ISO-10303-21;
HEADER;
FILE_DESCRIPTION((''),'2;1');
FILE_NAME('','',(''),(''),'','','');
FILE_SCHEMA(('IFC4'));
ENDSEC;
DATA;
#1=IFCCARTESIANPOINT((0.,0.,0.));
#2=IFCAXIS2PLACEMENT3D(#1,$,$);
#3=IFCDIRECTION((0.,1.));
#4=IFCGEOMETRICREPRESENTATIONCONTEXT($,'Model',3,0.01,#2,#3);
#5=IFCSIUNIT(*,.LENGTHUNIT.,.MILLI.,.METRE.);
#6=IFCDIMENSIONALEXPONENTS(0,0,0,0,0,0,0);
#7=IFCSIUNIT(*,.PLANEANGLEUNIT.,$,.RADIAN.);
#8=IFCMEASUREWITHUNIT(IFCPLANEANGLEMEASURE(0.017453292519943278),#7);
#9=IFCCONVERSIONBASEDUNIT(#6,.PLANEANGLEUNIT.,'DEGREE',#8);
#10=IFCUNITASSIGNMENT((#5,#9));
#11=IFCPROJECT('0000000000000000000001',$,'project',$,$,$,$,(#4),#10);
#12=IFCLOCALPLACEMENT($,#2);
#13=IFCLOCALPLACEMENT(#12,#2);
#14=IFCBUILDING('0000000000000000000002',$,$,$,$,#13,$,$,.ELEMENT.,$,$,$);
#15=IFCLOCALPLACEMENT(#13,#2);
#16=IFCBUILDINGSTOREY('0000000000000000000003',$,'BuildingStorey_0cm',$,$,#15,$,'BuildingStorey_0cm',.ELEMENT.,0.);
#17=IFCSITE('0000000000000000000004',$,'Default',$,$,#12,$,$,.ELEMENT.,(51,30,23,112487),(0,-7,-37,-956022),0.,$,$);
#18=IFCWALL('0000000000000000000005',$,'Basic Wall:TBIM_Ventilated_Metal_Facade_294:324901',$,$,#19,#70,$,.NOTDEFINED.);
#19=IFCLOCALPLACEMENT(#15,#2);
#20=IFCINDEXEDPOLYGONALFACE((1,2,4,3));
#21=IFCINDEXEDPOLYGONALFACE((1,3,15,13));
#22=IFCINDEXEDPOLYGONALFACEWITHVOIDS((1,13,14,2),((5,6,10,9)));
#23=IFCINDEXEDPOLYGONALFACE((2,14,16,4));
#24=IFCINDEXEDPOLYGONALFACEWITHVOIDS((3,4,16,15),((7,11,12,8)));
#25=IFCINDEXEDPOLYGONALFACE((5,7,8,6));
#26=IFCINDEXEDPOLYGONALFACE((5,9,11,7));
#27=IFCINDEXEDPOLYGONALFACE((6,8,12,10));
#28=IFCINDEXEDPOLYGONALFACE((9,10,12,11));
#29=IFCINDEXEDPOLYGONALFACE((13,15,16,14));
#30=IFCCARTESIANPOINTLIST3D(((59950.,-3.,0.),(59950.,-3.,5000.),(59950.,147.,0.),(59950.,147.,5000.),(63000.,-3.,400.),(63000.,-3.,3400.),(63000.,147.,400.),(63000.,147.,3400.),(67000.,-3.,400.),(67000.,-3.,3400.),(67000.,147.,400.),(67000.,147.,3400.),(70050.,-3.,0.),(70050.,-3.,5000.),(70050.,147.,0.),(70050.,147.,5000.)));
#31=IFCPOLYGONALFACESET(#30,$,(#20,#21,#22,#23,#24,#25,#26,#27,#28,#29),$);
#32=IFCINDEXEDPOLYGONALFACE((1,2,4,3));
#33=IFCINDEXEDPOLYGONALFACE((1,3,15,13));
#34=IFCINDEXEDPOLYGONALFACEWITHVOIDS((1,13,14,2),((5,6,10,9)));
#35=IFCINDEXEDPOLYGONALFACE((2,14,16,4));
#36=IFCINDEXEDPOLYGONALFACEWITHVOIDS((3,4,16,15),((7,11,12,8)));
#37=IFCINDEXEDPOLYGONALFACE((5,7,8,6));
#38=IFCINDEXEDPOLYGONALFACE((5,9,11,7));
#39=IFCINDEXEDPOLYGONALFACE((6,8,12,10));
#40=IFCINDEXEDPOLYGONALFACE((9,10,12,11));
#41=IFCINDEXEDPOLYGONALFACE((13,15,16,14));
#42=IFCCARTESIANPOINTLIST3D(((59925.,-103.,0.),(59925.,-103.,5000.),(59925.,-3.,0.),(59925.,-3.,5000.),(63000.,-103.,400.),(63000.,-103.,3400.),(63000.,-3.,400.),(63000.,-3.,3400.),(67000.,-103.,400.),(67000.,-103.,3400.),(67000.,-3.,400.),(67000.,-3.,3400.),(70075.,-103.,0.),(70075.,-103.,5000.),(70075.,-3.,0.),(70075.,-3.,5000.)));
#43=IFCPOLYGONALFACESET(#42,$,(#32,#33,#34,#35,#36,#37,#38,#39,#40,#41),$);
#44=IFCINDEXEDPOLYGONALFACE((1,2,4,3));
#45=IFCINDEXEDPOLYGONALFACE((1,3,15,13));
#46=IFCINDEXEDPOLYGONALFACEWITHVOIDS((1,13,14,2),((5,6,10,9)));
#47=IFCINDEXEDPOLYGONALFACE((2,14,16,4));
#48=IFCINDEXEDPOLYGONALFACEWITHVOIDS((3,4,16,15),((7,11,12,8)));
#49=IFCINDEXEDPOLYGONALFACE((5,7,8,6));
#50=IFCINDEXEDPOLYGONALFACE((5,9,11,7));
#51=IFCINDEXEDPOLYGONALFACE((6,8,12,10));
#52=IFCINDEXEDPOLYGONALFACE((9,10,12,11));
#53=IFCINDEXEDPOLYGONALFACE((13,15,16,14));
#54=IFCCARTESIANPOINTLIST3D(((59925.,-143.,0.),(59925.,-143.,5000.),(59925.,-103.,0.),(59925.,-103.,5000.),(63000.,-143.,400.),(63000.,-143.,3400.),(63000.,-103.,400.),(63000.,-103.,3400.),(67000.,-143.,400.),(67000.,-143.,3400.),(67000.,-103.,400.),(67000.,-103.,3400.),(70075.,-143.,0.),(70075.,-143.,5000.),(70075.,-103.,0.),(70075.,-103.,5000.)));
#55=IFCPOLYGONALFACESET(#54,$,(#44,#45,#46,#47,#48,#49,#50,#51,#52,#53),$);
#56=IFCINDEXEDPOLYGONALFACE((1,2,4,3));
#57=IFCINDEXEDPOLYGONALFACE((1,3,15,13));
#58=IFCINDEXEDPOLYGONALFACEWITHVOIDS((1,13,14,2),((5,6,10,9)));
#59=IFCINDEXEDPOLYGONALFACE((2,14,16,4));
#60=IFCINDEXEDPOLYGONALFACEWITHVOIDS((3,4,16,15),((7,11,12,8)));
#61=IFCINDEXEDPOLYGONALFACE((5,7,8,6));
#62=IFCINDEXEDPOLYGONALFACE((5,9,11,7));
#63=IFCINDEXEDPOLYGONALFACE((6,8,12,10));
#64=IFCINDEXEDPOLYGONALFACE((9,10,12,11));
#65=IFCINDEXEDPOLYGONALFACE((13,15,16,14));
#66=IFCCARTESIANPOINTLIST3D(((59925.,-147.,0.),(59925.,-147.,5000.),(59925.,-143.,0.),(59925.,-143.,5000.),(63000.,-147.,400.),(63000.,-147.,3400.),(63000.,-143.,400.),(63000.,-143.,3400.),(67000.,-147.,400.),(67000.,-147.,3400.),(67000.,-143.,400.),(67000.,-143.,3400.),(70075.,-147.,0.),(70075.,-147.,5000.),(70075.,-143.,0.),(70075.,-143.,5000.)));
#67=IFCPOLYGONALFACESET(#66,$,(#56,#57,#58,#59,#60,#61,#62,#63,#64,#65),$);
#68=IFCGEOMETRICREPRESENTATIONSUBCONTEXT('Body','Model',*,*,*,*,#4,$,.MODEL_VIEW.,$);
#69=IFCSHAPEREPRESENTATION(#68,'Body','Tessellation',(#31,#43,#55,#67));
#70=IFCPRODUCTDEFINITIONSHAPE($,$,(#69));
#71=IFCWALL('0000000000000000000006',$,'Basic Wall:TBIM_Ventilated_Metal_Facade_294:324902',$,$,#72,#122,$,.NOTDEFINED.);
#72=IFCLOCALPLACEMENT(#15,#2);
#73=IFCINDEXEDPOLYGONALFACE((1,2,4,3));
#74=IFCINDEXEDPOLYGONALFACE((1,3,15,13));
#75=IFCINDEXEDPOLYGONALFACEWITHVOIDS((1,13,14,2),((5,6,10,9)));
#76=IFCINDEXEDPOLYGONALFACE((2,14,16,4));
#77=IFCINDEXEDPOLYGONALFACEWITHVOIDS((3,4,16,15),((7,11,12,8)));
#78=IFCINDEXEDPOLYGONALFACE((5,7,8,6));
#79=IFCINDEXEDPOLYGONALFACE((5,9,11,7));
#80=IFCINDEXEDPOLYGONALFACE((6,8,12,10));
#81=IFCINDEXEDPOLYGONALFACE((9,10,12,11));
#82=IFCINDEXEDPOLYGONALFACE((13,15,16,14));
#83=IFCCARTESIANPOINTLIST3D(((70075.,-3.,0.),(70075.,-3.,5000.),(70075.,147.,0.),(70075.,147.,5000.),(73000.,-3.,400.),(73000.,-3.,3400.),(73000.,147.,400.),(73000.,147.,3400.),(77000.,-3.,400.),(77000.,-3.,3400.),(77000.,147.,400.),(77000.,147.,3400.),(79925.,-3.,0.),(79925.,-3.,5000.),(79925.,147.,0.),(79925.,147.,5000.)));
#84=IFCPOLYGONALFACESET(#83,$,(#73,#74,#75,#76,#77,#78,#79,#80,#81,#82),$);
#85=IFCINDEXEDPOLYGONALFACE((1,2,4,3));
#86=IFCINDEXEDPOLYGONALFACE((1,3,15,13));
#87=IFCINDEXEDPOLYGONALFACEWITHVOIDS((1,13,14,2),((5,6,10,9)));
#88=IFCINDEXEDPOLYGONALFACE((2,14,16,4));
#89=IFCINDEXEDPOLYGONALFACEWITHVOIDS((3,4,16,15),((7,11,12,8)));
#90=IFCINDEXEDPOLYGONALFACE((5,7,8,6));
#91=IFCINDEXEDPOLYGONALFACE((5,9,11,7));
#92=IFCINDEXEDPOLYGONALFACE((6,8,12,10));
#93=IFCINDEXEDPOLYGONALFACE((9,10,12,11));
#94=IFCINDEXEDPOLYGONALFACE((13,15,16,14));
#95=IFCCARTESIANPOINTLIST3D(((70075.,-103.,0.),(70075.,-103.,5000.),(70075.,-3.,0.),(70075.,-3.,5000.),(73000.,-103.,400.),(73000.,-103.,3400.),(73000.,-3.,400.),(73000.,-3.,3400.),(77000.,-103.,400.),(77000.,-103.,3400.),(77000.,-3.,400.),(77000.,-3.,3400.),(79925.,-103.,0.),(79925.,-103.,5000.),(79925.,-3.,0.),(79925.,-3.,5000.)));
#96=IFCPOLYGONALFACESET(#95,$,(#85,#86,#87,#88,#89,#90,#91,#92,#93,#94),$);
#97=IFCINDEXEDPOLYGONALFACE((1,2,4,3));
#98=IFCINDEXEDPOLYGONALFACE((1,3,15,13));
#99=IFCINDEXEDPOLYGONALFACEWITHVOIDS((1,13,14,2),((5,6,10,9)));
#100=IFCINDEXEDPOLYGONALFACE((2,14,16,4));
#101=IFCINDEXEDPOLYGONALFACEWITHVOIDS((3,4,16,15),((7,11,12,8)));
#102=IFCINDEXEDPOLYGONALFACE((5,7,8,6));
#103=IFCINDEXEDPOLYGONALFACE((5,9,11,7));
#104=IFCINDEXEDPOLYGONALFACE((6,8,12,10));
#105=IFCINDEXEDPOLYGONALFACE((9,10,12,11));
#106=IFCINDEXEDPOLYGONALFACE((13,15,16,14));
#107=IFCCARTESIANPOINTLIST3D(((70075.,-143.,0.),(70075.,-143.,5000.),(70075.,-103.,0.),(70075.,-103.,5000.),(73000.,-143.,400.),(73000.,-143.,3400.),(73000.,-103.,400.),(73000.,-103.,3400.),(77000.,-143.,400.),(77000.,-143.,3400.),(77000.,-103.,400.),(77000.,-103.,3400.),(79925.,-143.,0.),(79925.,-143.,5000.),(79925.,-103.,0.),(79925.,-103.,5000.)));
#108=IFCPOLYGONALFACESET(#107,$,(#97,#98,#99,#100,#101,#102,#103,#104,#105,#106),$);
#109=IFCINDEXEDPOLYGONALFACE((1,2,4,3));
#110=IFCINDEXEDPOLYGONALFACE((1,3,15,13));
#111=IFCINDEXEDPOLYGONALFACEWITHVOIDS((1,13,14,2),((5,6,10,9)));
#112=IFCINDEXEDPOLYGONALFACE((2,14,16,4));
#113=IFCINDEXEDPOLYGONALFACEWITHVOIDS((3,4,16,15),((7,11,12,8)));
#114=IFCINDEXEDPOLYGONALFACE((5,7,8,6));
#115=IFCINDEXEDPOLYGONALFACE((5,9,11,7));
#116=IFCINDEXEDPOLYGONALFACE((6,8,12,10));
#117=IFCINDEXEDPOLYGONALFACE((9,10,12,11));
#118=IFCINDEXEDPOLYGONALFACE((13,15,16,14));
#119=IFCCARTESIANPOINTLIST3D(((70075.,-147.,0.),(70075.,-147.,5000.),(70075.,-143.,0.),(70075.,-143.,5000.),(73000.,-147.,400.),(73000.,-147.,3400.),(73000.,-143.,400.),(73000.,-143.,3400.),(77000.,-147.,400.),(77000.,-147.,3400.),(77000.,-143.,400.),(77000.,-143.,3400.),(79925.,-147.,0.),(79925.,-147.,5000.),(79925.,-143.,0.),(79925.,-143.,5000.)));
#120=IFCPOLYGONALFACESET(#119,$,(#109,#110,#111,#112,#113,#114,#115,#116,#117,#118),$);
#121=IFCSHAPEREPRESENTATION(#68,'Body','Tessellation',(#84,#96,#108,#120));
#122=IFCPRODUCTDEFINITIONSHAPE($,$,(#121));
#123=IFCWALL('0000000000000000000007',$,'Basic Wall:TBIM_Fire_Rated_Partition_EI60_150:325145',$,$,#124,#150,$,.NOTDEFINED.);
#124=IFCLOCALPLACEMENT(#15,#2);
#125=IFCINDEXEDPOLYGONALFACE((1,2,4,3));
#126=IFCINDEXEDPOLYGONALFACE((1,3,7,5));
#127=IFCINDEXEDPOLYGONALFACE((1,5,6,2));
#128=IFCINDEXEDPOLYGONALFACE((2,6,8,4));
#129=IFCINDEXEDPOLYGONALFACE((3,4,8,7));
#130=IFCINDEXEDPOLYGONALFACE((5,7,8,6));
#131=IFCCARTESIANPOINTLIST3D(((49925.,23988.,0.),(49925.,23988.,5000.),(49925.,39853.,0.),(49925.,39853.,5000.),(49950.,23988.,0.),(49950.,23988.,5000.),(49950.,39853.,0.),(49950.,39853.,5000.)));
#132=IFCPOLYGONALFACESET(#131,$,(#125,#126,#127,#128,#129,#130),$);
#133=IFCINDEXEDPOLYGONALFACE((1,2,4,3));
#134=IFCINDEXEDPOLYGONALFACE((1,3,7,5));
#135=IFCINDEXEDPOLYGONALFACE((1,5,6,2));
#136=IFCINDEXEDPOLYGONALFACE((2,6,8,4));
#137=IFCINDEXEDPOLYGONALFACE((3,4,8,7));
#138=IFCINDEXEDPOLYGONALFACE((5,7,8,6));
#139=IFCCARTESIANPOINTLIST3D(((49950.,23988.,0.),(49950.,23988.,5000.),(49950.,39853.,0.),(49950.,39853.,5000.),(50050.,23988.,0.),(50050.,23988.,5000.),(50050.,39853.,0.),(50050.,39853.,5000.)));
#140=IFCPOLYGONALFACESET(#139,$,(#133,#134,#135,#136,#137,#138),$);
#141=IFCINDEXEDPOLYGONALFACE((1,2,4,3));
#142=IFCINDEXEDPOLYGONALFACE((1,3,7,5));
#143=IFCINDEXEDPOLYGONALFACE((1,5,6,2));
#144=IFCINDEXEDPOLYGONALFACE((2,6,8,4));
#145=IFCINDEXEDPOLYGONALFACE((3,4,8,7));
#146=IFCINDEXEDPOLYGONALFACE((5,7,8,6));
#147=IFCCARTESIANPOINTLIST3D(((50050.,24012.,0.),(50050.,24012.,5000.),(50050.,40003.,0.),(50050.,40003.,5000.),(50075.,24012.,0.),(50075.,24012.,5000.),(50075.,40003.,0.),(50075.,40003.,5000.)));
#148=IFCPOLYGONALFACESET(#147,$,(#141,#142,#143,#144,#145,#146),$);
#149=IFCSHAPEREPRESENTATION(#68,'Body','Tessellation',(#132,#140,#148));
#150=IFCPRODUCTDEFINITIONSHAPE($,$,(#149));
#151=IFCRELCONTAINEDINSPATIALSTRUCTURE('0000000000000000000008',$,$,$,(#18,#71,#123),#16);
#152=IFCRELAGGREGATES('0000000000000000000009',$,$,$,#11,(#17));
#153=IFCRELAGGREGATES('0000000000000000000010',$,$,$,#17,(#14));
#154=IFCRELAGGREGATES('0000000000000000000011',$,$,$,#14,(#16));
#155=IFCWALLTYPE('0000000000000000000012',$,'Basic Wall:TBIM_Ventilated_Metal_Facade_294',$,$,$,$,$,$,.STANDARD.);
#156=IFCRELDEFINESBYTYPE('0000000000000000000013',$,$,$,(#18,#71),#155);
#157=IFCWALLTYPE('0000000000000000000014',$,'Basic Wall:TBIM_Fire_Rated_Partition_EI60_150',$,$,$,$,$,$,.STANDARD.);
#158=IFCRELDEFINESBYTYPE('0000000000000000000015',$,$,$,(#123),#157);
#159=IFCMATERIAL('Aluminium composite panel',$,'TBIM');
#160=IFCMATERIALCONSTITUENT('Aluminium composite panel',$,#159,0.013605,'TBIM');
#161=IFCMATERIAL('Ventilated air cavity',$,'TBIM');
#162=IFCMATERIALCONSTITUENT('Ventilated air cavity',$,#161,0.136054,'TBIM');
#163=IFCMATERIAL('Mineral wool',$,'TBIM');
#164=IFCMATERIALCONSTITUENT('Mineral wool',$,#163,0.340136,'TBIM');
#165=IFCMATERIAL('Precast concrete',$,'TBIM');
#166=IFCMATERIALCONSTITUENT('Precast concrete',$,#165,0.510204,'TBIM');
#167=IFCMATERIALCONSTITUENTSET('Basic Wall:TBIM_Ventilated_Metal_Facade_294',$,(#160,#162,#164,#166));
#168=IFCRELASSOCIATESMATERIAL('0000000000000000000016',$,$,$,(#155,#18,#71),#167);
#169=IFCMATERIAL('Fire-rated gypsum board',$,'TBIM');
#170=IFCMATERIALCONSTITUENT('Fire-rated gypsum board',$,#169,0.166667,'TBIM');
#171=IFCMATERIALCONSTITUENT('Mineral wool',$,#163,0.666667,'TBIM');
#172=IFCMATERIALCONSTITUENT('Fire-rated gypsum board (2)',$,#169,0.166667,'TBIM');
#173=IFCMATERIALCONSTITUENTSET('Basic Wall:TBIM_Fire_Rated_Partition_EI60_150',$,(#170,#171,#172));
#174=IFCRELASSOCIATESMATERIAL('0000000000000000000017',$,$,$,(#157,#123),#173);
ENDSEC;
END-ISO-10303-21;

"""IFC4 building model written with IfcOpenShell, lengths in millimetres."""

from ifc_helpers import new_model, entity, si_unit, converted_unit, direction, frame, origin, place, context, subcontext, project, spatial, indexed_curve, outline, extrude, material, constituent, constituent_set, type_object, element, save


model = new_model("IFC4")

# Units and contexts
model_context = context("Model", 3, precision=0.01, world=origin(), true_north=direction((0.0, 1.0)))
body_context = subcontext(model_context, "Body", "Model", "MODEL_VIEW")
ifc_project = project(units=[si_unit("LENGTHUNIT", "METRE", prefix="MILLI"), converted_unit("PLANEANGLEUNIT", "DEGREE", entity("IfcPlaneAngleMeasure", 0.017453292519943278), si_unit("PLANEANGLEUNIT", "RADIAN"), dimensions=[0, 0, 0, 0, 0, 0, 0])], contexts=[model_context])

# Site, building, storey
site_placement = place(None, origin())
site = spatial("IfcSite", under=ifc_project, at=site_placement, Name="Default", CompositionType="ELEMENT", RefLatitude=(51, 30, 23, 112487), RefLongitude=(0, -7, -37, -956022), RefElevation=0.0)
building_placement = place(site_placement, origin())
building = spatial("IfcBuilding", under=site, at=building_placement, CompositionType="ELEMENT")
storey_placement = place(building_placement, origin())
storey = spatial("IfcBuildingStorey", under=building, at=storey_placement, Name="BuildingStorey_0cm", LongName="BuildingStorey_0cm", CompositionType="ELEMENT", Elevation=0.0)

# Walls, openings
ifc_material_1 = material(Name="Aluminium composite panel", Category="TBIM")
ifc_constituent_1 = constituent(ifc_material_1, Name="Aluminium composite panel", Category="TBIM", fraction=0.013605)
ifc_material_2 = material(Name="Ventilated air cavity", Category="TBIM")
ifc_constituent_2 = constituent(ifc_material_2, Name="Ventilated air cavity", Category="TBIM", fraction=0.136054)
ifc_material_3 = material(Name="Mineral wool", Category="TBIM")
ifc_constituent_3 = constituent(ifc_material_3, Name="Mineral wool", Category="TBIM", fraction=0.340136)
ifc_material_4 = material(Name="Precast concrete", Category="TBIM")
ifc_constituent_4 = constituent(ifc_material_4, Name="Precast concrete", Category="TBIM", fraction=0.510204)
ifc_constituent_set_1 = constituent_set(constituents=[ifc_constituent_1, ifc_constituent_2, ifc_constituent_3, ifc_constituent_4], Name="Basic Wall:TBIM_Ventilated_Metal_Facade_294")
wall_type_1 = type_object("IfcWallType", Name="Basic Wall:TBIM_Ventilated_Metal_Facade_294", PredefinedType="STANDARD", material=ifc_constituent_set_1)
wall_1_placement = place(storey_placement, frame((59925.0, 0.0, 0.0)))
wall_1 = element("IfcWall", 1, at=wall_1_placement, inside=storey, type_object=wall_type_1, material=ifc_constituent_set_1, Name="Basic Wall:TBIM_Ventilated_Metal_Facade_294:324901", PredefinedType="NOTDEFINED", context=body_context, shape_type="SweptSolid", body=[
    extrude(outline(indexed_curve([(-2500.0, -5050.0), (2500.0, -5050.0), (2500.0, 5050.0), (-2500.0, 5050.0), (-2500.0, -5050.0)], self_intersect=False), holes=[indexed_curve([(-2100.0, -2000.0), (-2100.0, 2000.0), (900.0, 2000.0), (900.0, -2000.0), (-2100.0, -2000.0)], self_intersect=False)]), frame((5075.0, -3.0, 2500.0), z_axis=(0.0, 1.0, 0.0), x_axis=(0.0, 0.0, 1.0)), (0.0, 0.0, 1.0), 150.0),
    extrude(outline(indexed_curve([(-2500.0, -5075.0), (2500.0, -5075.0), (2500.0, 5075.0), (-2500.0, 5075.0), (-2500.0, -5075.0)], self_intersect=False), holes=[indexed_curve([(-2100.0, -2000.0), (-2100.0, 2000.0), (900.0, 2000.0), (900.0, -2000.0), (-2100.0, -2000.0)], self_intersect=False)]), frame((5075.0, -103.0, 2500.0), z_axis=(0.0, 1.0, 0.0), x_axis=(0.0, 0.0, 1.0)), (0.0, 0.0, 1.0), 100.0),
    extrude(outline(indexed_curve([(-2500.0, -5075.0), (2500.0, -5075.0), (2500.0, 5075.0), (-2500.0, 5075.0), (-2500.0, -5075.0)], self_intersect=False), holes=[indexed_curve([(-2100.0, -2000.0), (-2100.0, 2000.0), (900.0, 2000.0), (900.0, -2000.0), (-2100.0, -2000.0)], self_intersect=False)]), frame((5075.0, -143.0, 2500.0), z_axis=(0.0, 1.0, 0.0), x_axis=(0.0, 0.0, 1.0)), (0.0, 0.0, 1.0), 40.0),
    extrude(outline(indexed_curve([(-2500.0, -5075.0), (2500.0, -5075.0), (2500.0, 5075.0), (-2500.0, 5075.0), (-2500.0, -5075.0)], self_intersect=False), holes=[indexed_curve([(900.0, -2000.0), (-2100.0, -2000.0), (-2100.0, 2000.0), (900.0, 2000.0), (900.0, -2000.0)], self_intersect=False)]), frame((5075.0, -147.0, 2500.0), z_axis=(0.0, 1.0, 0.0), x_axis=(0.0, 0.0, 1.0)), (0.0, 0.0, 1.0), 4.0),
])
opening_1_placement = place(wall_1_placement, frame((3075.0, -147.0, 400.0)))
element("IfcOpeningElement", 2, at=opening_1_placement, cuts=wall_1, PredefinedType="OPENING", context=body_context, shape_type="SweptSolid", body=[
    extrude(outline(indexed_curve([(3000.0, 0.0), (3000.0, 4000.0), (0.0, 4000.0), (0.0, 0.0), (3000.0, 0.0)], self_intersect=False)), frame((0.0, 0.0, 0.0), z_axis=(0.0, 1.0, 0.0), x_axis=(0.0, 0.0, 1.0)), (0.0, 0.0, 1.0), 294.0),
])
wall_2_placement = place(storey_placement, frame((70075.0, 0.0, 0.0)))
wall_2 = element("IfcWall", 3, at=wall_2_placement, inside=storey, type_object=wall_type_1, material=ifc_constituent_set_1, Name="Basic Wall:TBIM_Ventilated_Metal_Facade_294:324902", PredefinedType="NOTDEFINED", context=body_context, shape_type="SweptSolid", body=[
    extrude(outline(indexed_curve([(-2500.0, -4925.0), (2500.0, -4925.0), (2500.0, 4925.0), (-2500.0, 4925.0), (-2500.0, -4925.0)], self_intersect=False), holes=[indexed_curve([(-2100.0, -2000.0), (-2100.0, 2000.0), (900.0, 2000.0), (900.0, -2000.0), (-2100.0, -2000.0)], self_intersect=False)]), frame((4925.0, -3.0, 2500.0), z_axis=(0.0, 1.0, 0.0), x_axis=(0.0, 0.0, 1.0)), (0.0, 0.0, 1.0), 150.0),
    extrude(outline(indexed_curve([(-2500.0, -4925.0), (2500.0, -4925.0), (2500.0, 4925.0), (-2500.0, 4925.0), (-2500.0, -4925.0)], self_intersect=False), holes=[indexed_curve([(-2100.0, -2000.0), (-2100.0, 2000.0), (900.0, 2000.0), (900.0, -2000.0), (-2100.0, -2000.0)], self_intersect=False)]), frame((4925.0, -103.0, 2500.0), z_axis=(0.0, 1.0, 0.0), x_axis=(0.0, 0.0, 1.0)), (0.0, 0.0, 1.0), 100.0),
    extrude(outline(indexed_curve([(-2500.0, -4925.0), (2500.0, -4925.0), (2500.0, 4925.0), (-2500.0, 4925.0), (-2500.0, -4925.0)], self_intersect=False), holes=[indexed_curve([(-2100.0, -2000.0), (-2100.0, 2000.0), (900.0, 2000.0), (900.0, -2000.0), (-2100.0, -2000.0)], self_intersect=False)]), frame((4925.0, -143.0, 2500.0), z_axis=(0.0, 1.0, 0.0), x_axis=(0.0, 0.0, 1.0)), (0.0, 0.0, 1.0), 40.0),
    extrude(outline(indexed_curve([(-2500.0, -4925.0), (2500.0, -4925.0), (2500.0, 4925.0), (-2500.0, 4925.0), (-2500.0, -4925.0)], self_intersect=False), holes=[indexed_curve([(900.0, -2000.0), (-2100.0, -2000.0), (-2100.0, 2000.0), (900.0, 2000.0), (900.0, -2000.0)], self_intersect=False)]), frame((4925.0, -147.0, 2500.0), z_axis=(0.0, 1.0, 0.0), x_axis=(0.0, 0.0, 1.0)), (0.0, 0.0, 1.0), 4.0),
])
opening_2_placement = place(wall_2_placement, frame((2925.0, -147.0, 400.0)))
element("IfcOpeningElement", 4, at=opening_2_placement, cuts=wall_2, PredefinedType="OPENING", context=body_context, shape_type="SweptSolid", body=[
    extrude(outline(indexed_curve([(3000.0, 0.0), (3000.0, 4000.0), (0.0, 4000.0), (0.0, 0.0), (3000.0, 0.0)], self_intersect=False)), frame((0.0, 0.0, 0.0), z_axis=(0.0, 1.0, 0.0), x_axis=(0.0, 0.0, 1.0)), (0.0, 0.0, 1.0), 294.0),
])

# Wall
ifc_material_5 = material(Name="Fire-rated gypsum board", Category="TBIM")
ifc_constituent_5 = constituent(ifc_material_5, Name="Fire-rated gypsum board", Category="TBIM", fraction=0.166667)
ifc_constituent_6 = constituent(ifc_material_3, Name="Mineral wool", Category="TBIM", fraction=0.666667)
ifc_constituent_7 = constituent(ifc_material_5, Name="Fire-rated gypsum board (2)", Category="TBIM", fraction=0.166667)
ifc_constituent_set_2 = constituent_set(constituents=[ifc_constituent_5, ifc_constituent_6, ifc_constituent_7], Name="Basic Wall:TBIM_Fire_Rated_Partition_EI60_150")
wall_type_2 = type_object("IfcWallType", Name="Basic Wall:TBIM_Fire_Rated_Partition_EI60_150", PredefinedType="STANDARD", material=ifc_constituent_set_2)
wall_3_placement = place(storey_placement, frame((50000.0, 24012.0, 0.0), z_axis=(0.0, 0.0, 1.0), x_axis=(0.0, 1.0, 0.0)))
element("IfcWall", 5, at=wall_3_placement, inside=storey, type_object=wall_type_2, material=ifc_constituent_set_2, Name="Basic Wall:TBIM_Fire_Rated_Partition_EI60_150:325145", PredefinedType="NOTDEFINED", context=body_context, shape_type="SweptSolid", body=[
    extrude(outline(indexed_curve([(-12.5, -7932.5), (12.5, -7932.5), (12.5, 7932.5), (-12.5, 7932.5), (-12.5, -7932.5)], self_intersect=False)), frame((7908.5, 62.5, 0.0), z_axis=(0.0, 0.0, 1.0), x_axis=(0.0, -1.0, 0.0)), (0.0, 0.0, 1.0), 5000.0),
    extrude(outline(indexed_curve([(-7932.5, -50.0), (7932.5, -50.0), (7932.5, 50.0), (-7932.5, 50.0), (-7932.5, -50.0)], self_intersect=False)), frame((7908.5, 0.0, 0.0)), (0.0, 0.0, 1.0), 5000.0),
    extrude(outline(indexed_curve([(-12.5, -7995.5), (12.5, -7995.5), (12.5, 7995.5), (-12.5, 7995.5), (-12.5, -7995.5)], self_intersect=False)), frame((7995.5, -62.5, 0.0), z_axis=(0.0, 0.0, 1.0), x_axis=(0.0, 1.0, 0.0)), (0.0, 0.0, 1.0), 5000.0),
])

save(model, "model.ifc")
